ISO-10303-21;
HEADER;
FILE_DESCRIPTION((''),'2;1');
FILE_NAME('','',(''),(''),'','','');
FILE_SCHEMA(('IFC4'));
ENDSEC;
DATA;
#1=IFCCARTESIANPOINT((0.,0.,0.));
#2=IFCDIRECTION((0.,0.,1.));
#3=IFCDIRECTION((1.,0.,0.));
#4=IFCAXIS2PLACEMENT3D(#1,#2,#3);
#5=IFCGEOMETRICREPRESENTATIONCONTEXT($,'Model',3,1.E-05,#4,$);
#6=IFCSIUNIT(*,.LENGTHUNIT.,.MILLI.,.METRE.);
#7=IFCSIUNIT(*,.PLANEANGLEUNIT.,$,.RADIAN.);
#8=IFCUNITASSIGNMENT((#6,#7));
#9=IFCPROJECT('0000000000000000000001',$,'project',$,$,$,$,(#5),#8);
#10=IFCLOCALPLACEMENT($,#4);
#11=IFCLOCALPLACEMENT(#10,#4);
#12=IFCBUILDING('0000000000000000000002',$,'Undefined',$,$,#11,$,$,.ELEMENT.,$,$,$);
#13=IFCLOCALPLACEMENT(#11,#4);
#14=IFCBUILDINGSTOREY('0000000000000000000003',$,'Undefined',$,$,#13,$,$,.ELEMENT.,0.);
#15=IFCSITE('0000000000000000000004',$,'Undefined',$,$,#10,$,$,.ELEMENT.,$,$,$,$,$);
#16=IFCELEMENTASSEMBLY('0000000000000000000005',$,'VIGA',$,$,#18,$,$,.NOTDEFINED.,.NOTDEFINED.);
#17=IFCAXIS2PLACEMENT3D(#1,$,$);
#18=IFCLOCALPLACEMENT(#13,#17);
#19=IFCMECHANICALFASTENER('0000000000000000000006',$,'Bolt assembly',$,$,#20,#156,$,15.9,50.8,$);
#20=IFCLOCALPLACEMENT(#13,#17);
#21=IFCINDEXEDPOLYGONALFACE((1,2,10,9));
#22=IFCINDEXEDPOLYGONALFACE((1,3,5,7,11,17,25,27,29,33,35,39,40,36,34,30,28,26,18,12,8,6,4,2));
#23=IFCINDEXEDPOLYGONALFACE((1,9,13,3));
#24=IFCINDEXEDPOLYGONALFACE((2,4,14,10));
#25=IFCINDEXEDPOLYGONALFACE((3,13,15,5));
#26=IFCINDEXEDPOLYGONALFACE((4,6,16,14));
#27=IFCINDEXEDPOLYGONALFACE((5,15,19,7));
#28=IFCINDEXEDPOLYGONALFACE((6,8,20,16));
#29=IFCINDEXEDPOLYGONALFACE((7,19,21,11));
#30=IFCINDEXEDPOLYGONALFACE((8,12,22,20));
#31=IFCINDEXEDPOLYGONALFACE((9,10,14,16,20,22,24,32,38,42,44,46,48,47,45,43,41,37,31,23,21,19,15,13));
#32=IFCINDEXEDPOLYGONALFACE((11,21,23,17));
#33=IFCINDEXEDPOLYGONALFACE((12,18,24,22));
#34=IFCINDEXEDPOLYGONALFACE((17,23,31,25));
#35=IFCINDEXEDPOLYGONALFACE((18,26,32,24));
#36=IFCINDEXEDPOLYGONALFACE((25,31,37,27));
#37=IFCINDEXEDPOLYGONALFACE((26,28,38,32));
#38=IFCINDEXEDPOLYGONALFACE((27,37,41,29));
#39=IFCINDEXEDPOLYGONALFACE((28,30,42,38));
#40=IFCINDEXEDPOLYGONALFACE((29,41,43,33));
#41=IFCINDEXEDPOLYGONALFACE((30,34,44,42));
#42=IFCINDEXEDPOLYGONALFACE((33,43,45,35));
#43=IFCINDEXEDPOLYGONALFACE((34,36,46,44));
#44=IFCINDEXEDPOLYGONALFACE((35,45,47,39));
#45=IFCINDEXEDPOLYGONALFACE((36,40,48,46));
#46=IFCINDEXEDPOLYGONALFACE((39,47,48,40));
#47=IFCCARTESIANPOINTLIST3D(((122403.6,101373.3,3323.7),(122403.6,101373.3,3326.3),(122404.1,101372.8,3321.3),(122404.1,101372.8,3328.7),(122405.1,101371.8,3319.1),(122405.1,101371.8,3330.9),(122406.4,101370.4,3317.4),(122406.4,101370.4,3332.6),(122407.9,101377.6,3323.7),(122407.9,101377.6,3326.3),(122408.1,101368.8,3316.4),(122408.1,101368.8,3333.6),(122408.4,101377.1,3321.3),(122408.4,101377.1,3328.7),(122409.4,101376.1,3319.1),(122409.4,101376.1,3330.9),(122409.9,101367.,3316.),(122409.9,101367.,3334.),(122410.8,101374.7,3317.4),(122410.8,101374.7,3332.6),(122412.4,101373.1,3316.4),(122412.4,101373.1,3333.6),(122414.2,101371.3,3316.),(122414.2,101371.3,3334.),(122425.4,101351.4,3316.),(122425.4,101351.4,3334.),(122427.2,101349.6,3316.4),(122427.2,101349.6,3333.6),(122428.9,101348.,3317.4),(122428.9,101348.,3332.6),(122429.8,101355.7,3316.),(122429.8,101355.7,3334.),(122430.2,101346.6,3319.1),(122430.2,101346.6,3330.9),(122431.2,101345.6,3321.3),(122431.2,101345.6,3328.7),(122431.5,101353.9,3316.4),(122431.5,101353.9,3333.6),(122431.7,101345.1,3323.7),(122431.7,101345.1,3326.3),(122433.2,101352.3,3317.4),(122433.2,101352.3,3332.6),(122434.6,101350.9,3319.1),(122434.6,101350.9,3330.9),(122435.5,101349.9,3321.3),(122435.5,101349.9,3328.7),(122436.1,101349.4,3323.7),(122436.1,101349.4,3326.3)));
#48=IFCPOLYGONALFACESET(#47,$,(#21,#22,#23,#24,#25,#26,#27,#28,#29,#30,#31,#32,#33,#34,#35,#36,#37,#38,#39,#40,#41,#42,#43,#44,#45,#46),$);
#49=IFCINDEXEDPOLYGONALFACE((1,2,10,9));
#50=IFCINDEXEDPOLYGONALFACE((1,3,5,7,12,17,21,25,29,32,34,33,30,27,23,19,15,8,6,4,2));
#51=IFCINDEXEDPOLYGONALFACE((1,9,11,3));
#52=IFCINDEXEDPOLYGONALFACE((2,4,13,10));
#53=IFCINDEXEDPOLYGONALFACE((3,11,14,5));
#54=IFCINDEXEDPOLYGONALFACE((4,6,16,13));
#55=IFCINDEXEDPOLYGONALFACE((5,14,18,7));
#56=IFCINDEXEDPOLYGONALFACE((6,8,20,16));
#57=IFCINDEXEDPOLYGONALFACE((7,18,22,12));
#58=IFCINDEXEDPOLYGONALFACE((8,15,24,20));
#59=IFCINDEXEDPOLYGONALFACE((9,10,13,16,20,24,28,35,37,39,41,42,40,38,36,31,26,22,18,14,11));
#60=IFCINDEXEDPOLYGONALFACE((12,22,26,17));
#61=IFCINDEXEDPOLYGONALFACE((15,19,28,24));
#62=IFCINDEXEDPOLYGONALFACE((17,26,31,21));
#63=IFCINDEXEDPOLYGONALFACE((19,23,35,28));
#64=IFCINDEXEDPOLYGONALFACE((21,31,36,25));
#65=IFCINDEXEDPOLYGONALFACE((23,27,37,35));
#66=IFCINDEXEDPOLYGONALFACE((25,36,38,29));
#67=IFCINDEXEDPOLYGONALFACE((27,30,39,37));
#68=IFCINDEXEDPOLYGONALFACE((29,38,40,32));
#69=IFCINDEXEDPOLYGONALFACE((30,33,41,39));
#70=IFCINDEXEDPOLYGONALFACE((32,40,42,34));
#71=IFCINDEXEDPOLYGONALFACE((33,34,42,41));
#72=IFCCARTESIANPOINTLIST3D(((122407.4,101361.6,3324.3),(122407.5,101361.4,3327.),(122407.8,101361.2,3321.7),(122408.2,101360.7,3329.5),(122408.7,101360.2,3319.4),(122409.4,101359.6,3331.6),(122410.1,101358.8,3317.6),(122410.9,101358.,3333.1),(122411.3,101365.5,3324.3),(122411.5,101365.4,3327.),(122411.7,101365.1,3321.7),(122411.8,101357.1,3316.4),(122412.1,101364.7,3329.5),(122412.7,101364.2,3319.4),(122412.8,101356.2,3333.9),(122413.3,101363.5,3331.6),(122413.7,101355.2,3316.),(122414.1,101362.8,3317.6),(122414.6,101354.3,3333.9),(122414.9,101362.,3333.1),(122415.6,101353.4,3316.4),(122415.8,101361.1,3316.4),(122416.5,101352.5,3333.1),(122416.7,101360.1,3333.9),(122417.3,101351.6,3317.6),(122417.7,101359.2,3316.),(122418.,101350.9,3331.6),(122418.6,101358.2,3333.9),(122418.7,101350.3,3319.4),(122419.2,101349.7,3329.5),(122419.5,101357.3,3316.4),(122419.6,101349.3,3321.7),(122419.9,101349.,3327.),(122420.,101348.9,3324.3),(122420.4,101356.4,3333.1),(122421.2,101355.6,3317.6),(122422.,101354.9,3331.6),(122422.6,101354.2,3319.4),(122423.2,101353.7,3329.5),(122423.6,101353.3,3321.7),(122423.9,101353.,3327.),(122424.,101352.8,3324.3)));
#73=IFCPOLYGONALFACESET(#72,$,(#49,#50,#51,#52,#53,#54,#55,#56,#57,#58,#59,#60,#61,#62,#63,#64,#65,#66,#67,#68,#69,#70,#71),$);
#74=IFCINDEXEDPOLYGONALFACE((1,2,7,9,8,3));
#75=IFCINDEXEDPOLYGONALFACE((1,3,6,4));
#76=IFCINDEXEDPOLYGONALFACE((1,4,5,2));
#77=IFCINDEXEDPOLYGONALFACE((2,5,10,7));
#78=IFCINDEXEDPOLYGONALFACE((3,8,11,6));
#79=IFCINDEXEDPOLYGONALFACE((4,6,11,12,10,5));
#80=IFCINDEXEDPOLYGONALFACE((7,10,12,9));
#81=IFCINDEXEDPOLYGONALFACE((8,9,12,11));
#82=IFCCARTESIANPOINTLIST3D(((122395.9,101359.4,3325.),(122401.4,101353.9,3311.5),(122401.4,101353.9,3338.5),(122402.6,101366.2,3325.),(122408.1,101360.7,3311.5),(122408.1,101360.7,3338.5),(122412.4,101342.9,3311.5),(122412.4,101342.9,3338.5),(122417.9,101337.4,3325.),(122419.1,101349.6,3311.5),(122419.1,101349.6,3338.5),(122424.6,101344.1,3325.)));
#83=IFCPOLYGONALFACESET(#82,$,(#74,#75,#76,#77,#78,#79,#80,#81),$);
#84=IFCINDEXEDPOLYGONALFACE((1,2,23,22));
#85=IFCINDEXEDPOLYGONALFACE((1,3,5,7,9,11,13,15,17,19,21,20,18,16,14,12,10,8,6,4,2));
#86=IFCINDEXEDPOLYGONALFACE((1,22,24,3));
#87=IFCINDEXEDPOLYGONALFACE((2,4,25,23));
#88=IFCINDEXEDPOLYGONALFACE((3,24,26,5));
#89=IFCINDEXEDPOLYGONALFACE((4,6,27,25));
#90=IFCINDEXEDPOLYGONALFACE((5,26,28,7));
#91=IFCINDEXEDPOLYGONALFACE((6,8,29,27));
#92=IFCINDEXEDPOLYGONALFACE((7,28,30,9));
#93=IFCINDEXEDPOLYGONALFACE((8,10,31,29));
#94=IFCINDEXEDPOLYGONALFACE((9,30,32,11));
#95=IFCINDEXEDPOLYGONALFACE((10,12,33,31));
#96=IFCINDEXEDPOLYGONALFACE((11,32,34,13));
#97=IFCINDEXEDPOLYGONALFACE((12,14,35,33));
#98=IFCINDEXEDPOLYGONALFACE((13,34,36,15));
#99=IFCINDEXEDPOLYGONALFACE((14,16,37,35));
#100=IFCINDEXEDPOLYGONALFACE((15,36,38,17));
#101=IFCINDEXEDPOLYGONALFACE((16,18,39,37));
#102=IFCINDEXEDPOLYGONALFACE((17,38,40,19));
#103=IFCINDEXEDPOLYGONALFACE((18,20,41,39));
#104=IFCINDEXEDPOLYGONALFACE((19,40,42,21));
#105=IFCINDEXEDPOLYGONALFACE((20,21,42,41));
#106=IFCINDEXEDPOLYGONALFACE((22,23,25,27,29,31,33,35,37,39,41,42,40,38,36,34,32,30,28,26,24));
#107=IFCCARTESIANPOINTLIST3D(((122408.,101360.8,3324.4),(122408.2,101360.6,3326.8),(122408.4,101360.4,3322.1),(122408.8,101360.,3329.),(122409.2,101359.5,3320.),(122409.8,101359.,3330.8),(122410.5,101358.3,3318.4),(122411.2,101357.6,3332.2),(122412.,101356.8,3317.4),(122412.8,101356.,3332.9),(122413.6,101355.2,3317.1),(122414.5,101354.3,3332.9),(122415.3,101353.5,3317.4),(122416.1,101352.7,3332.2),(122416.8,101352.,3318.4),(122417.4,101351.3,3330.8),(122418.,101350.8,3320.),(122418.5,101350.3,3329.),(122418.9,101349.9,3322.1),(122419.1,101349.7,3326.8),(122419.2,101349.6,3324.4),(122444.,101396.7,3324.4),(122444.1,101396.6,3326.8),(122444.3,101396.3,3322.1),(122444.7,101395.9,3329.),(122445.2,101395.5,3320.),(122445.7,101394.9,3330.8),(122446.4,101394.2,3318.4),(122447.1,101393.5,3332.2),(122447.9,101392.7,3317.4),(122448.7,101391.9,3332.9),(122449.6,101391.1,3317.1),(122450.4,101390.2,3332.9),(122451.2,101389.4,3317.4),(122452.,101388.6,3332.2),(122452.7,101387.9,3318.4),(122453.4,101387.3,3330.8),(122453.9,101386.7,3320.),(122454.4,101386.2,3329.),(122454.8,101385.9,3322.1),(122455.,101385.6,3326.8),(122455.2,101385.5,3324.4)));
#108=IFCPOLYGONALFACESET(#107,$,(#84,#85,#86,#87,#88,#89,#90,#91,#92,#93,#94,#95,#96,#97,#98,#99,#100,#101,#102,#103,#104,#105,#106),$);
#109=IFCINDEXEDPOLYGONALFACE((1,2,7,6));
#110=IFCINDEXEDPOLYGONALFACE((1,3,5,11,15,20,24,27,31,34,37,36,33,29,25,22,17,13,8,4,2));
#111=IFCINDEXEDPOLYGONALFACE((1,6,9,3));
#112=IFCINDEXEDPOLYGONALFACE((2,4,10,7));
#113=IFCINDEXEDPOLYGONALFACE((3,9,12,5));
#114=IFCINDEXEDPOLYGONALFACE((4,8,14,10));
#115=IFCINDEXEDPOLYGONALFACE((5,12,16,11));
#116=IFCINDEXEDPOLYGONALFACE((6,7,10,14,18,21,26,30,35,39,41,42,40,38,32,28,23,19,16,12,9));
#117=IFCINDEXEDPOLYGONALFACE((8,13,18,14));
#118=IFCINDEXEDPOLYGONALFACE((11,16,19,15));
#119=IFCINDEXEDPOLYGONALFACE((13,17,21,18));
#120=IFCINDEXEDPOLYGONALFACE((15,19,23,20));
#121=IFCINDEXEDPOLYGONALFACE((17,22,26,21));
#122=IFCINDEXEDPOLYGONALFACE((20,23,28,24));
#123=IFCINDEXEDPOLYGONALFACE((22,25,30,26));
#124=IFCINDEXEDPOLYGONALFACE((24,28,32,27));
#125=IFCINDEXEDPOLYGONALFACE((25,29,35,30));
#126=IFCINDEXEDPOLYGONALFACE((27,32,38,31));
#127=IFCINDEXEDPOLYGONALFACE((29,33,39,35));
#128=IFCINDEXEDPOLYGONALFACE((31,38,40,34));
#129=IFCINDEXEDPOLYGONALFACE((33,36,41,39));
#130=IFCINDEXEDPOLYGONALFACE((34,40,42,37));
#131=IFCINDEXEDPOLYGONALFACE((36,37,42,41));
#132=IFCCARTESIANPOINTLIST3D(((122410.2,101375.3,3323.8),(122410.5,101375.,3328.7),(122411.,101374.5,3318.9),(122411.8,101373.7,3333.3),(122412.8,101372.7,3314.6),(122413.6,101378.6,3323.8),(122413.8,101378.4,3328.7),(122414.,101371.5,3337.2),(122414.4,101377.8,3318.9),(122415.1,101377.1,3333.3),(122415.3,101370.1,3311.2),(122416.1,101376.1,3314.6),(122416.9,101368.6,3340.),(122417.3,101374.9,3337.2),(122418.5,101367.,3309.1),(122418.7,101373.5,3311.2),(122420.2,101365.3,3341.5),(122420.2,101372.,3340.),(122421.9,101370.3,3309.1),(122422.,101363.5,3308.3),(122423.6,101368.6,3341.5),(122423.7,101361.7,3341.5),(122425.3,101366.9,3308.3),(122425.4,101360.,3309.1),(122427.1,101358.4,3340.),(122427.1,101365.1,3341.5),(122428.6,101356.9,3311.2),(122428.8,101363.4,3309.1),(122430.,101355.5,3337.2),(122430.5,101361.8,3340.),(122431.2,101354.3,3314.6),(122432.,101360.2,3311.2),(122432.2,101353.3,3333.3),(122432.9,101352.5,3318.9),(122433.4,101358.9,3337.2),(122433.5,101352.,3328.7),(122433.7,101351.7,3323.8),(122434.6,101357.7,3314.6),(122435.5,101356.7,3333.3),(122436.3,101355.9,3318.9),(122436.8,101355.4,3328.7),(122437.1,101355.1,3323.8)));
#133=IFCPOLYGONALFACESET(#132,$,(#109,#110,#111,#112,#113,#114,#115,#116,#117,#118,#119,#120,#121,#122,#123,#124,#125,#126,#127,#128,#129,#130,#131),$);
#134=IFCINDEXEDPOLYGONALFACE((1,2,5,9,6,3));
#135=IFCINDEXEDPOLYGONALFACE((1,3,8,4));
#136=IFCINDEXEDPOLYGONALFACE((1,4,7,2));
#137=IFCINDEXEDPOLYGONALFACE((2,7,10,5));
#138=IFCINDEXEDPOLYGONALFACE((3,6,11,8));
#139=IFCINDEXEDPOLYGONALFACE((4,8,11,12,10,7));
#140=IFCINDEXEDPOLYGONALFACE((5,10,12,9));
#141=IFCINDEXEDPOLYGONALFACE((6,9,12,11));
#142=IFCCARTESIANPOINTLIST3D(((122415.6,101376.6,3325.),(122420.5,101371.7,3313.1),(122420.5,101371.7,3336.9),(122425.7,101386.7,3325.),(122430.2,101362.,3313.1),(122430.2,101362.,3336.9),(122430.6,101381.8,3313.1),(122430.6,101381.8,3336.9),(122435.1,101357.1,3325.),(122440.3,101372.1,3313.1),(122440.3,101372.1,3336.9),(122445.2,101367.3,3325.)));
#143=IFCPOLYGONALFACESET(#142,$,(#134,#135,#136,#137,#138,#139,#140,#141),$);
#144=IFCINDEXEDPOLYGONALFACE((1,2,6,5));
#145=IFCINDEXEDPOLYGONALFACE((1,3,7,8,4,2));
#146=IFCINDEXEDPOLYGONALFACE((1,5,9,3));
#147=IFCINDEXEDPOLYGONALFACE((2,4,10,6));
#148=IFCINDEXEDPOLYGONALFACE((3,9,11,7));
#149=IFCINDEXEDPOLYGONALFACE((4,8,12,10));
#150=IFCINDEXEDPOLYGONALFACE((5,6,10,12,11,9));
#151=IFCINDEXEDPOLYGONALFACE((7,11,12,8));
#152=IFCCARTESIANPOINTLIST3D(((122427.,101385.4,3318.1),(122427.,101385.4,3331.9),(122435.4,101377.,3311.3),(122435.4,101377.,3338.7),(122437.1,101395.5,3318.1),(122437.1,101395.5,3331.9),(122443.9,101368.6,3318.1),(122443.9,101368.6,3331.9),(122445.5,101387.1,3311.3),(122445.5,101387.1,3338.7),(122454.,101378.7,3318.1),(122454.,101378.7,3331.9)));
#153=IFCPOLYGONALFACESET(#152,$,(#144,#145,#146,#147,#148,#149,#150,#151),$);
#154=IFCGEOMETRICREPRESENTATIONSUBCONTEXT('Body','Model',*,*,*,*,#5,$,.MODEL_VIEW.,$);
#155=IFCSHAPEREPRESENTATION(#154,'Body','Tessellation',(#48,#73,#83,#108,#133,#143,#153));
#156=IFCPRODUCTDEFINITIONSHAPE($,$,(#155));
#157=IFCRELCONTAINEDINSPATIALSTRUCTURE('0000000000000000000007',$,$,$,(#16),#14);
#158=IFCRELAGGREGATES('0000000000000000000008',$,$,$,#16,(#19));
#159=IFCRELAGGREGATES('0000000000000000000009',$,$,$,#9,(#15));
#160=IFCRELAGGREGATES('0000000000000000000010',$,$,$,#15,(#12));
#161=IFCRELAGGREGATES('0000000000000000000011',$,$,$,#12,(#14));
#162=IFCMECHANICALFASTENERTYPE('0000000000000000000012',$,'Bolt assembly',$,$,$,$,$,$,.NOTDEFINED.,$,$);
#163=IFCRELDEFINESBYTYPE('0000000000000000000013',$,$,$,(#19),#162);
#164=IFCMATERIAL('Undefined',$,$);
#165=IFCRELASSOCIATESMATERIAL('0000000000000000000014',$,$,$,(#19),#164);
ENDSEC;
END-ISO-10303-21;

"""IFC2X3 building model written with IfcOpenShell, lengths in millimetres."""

from ifc_helpers import new_model, si_unit, frame, frame_2d, origin_with_axes, origin_2d_with_axis, place, context, subcontext, project, spatial, polyline, circle_curve, parameter, trimmed, segment, composite_curve, circle, outline, extrude, source, transform, mapped, material, type_object, element, aggregate, save


model = new_model("IFC2X3")

# Units and contexts
model_context = context("Model", 3, precision=1e-05, world=origin_with_axes())
body_context = subcontext(model_context, "Body", "Model", "MODEL_VIEW")
ifc_project = project(units=[si_unit("LENGTHUNIT", "METRE", prefix="MILLI"), si_unit("PLANEANGLEUNIT", "RADIAN")], contexts=[model_context])

# Site, building, storey
site_placement = place(None, origin_with_axes())
site = spatial("IfcSite", under=ifc_project, at=site_placement, Name="Undefined", CompositionType="ELEMENT")
building_placement = place(site_placement, origin_with_axes())
building = spatial("IfcBuilding", under=site, at=building_placement, Name="Undefined", CompositionType="ELEMENT")
storey_placement = place(building_placement, origin_with_axes())
storey = spatial("IfcBuildingStorey", under=building, at=storey_placement, Name="Undefined", CompositionType="ELEMENT", Elevation=0.0)

# Element assembly
assembly_1_placement = place(storey_placement, origin_with_axes())
assembly_1 = element("IfcElementAssembly", 1, at=assembly_1_placement, inside=storey, Name="VIGA", AssemblyPlace="NOTDEFINED", PredefinedType="NOTDEFINED")

# Mechanical fastener
ifc_material_1 = material(Name="Undefined")
mechanical_fastener_type = type_object("IfcMechanicalFastenerType", Name="Bolt assembly")
shared_shape_1 = source(origin_with_axes(), body_context, "Body", "SweptSolid", [
    extrude(outline(composite_curve([segment(polyline([(9.0, 11.0), (9.0, -11.0)]), True, "CONTINUOUS"), segment(trimmed(circle_curve(frame_2d((0.0, -11.0), x_axis=(1.0, 0.0)), 9.0), [parameter(0.0)], [parameter(3.141593)], False, "PARAMETER"), True, "CONTINUOUS"), segment(polyline([(-9.0, -11.0), (-9.0, 11.0)]), True, "CONTINUOUS"), segment(trimmed(circle_curve(frame_2d((0.0, 11.0), x_axis=(-1.0, 0.0)), 9.0), [parameter(0.0)], [parameter(3.141593)], False, "PARAMETER"), True, "DISCONTINUOUS")], self_intersect=False)), frame((0.0, 2.9, 0.0), z_axis=(0.0, 1.0, 0.0), x_axis=(1.0, 0.0, 0.0)), (0.0, 0.0, 1.0), 6.1),
    extrude(circle(Radius=9.0, at=origin_2d_with_axis()), frame((0.0, -2.7, 0.0), z_axis=(0.0, 1.0, 0.0), x_axis=(1.0, 0.0, 0.0)), (0.0, 0.0, 1.0), 5.6),
    extrude(outline(polyline([(13.5, -7.8), (13.5, 7.8), (0.0, 15.6), (-13.5, 7.8), (-13.5, -7.8), (0.0, -15.6), (13.5, -7.8)])), frame((0.0, -12.3, 0.0), z_axis=(0.0, 1.0, 0.0), x_axis=(1.0, 0.0, 0.0)), (0.0, 0.0, 1.0), 9.5),
    extrude(circle(Radius=7.9, at=origin_2d_with_axis()), frame((0.0, -2.8, 0.0), z_axis=(0.0, 1.0, 0.0), x_axis=(1.0, 0.0, 0.0)), (0.0, 0.0, 1.0), 50.8),
    extrude(circle(Radius=16.7, at=origin_2d_with_axis()), frame((0.0, 9.0, 0.0), z_axis=(0.0, 1.0, 0.0), x_axis=(1.0, 0.0, 0.0)), (0.0, 0.0, 1.0), 4.8),
    extrude(outline(polyline([(11.9, -6.9), (11.9, 6.9), (0.0, 13.7), (-11.9, 6.9), (-11.9, -6.9), (0.0, -13.7), (11.9, -6.9)])), frame((0.0, 13.8, 0.0), z_axis=(0.0, 1.0, 0.0), x_axis=(1.0, 0.0, 0.0)), (0.0, 0.0, 1.0), 14.3),
    extrude(outline(polyline([(13.7, 0.0), (6.9, 11.9), (-6.9, 11.9), (-13.7, 0.0), (-6.9, -11.9), (6.9, -11.9), (13.7, 0.0)])), frame((0.0, 28.0, 0.0), z_axis=(0.0, 1.0, 0.0), x_axis=(1.0, 0.0, 0.0)), (0.0, 0.0, 1.0), 14.3),
])
mechanical_fastener_1_placement = place(assembly_1_placement, frame((122415.6, 101357.1, 3325.0), z_axis=(0.707107, -0.707106, 0.0), x_axis=(0.0, 0.0, -1.0)))
mechanical_fastener_1 = element("IfcMechanicalFastener", 2, at=mechanical_fastener_1_placement, type_object=mechanical_fastener_type, material=ifc_material_1, Name="Bolt assembly", NominalDiameter=15.9, NominalLength=50.8, context=body_context, shape_type="MappedRepresentation", body=[
    mapped(shared_shape_1, transform((0.0, 0.0, 0.0))),
])
aggregate(assembly_1, [mechanical_fastener_1])

save(model, "model.ifc")
